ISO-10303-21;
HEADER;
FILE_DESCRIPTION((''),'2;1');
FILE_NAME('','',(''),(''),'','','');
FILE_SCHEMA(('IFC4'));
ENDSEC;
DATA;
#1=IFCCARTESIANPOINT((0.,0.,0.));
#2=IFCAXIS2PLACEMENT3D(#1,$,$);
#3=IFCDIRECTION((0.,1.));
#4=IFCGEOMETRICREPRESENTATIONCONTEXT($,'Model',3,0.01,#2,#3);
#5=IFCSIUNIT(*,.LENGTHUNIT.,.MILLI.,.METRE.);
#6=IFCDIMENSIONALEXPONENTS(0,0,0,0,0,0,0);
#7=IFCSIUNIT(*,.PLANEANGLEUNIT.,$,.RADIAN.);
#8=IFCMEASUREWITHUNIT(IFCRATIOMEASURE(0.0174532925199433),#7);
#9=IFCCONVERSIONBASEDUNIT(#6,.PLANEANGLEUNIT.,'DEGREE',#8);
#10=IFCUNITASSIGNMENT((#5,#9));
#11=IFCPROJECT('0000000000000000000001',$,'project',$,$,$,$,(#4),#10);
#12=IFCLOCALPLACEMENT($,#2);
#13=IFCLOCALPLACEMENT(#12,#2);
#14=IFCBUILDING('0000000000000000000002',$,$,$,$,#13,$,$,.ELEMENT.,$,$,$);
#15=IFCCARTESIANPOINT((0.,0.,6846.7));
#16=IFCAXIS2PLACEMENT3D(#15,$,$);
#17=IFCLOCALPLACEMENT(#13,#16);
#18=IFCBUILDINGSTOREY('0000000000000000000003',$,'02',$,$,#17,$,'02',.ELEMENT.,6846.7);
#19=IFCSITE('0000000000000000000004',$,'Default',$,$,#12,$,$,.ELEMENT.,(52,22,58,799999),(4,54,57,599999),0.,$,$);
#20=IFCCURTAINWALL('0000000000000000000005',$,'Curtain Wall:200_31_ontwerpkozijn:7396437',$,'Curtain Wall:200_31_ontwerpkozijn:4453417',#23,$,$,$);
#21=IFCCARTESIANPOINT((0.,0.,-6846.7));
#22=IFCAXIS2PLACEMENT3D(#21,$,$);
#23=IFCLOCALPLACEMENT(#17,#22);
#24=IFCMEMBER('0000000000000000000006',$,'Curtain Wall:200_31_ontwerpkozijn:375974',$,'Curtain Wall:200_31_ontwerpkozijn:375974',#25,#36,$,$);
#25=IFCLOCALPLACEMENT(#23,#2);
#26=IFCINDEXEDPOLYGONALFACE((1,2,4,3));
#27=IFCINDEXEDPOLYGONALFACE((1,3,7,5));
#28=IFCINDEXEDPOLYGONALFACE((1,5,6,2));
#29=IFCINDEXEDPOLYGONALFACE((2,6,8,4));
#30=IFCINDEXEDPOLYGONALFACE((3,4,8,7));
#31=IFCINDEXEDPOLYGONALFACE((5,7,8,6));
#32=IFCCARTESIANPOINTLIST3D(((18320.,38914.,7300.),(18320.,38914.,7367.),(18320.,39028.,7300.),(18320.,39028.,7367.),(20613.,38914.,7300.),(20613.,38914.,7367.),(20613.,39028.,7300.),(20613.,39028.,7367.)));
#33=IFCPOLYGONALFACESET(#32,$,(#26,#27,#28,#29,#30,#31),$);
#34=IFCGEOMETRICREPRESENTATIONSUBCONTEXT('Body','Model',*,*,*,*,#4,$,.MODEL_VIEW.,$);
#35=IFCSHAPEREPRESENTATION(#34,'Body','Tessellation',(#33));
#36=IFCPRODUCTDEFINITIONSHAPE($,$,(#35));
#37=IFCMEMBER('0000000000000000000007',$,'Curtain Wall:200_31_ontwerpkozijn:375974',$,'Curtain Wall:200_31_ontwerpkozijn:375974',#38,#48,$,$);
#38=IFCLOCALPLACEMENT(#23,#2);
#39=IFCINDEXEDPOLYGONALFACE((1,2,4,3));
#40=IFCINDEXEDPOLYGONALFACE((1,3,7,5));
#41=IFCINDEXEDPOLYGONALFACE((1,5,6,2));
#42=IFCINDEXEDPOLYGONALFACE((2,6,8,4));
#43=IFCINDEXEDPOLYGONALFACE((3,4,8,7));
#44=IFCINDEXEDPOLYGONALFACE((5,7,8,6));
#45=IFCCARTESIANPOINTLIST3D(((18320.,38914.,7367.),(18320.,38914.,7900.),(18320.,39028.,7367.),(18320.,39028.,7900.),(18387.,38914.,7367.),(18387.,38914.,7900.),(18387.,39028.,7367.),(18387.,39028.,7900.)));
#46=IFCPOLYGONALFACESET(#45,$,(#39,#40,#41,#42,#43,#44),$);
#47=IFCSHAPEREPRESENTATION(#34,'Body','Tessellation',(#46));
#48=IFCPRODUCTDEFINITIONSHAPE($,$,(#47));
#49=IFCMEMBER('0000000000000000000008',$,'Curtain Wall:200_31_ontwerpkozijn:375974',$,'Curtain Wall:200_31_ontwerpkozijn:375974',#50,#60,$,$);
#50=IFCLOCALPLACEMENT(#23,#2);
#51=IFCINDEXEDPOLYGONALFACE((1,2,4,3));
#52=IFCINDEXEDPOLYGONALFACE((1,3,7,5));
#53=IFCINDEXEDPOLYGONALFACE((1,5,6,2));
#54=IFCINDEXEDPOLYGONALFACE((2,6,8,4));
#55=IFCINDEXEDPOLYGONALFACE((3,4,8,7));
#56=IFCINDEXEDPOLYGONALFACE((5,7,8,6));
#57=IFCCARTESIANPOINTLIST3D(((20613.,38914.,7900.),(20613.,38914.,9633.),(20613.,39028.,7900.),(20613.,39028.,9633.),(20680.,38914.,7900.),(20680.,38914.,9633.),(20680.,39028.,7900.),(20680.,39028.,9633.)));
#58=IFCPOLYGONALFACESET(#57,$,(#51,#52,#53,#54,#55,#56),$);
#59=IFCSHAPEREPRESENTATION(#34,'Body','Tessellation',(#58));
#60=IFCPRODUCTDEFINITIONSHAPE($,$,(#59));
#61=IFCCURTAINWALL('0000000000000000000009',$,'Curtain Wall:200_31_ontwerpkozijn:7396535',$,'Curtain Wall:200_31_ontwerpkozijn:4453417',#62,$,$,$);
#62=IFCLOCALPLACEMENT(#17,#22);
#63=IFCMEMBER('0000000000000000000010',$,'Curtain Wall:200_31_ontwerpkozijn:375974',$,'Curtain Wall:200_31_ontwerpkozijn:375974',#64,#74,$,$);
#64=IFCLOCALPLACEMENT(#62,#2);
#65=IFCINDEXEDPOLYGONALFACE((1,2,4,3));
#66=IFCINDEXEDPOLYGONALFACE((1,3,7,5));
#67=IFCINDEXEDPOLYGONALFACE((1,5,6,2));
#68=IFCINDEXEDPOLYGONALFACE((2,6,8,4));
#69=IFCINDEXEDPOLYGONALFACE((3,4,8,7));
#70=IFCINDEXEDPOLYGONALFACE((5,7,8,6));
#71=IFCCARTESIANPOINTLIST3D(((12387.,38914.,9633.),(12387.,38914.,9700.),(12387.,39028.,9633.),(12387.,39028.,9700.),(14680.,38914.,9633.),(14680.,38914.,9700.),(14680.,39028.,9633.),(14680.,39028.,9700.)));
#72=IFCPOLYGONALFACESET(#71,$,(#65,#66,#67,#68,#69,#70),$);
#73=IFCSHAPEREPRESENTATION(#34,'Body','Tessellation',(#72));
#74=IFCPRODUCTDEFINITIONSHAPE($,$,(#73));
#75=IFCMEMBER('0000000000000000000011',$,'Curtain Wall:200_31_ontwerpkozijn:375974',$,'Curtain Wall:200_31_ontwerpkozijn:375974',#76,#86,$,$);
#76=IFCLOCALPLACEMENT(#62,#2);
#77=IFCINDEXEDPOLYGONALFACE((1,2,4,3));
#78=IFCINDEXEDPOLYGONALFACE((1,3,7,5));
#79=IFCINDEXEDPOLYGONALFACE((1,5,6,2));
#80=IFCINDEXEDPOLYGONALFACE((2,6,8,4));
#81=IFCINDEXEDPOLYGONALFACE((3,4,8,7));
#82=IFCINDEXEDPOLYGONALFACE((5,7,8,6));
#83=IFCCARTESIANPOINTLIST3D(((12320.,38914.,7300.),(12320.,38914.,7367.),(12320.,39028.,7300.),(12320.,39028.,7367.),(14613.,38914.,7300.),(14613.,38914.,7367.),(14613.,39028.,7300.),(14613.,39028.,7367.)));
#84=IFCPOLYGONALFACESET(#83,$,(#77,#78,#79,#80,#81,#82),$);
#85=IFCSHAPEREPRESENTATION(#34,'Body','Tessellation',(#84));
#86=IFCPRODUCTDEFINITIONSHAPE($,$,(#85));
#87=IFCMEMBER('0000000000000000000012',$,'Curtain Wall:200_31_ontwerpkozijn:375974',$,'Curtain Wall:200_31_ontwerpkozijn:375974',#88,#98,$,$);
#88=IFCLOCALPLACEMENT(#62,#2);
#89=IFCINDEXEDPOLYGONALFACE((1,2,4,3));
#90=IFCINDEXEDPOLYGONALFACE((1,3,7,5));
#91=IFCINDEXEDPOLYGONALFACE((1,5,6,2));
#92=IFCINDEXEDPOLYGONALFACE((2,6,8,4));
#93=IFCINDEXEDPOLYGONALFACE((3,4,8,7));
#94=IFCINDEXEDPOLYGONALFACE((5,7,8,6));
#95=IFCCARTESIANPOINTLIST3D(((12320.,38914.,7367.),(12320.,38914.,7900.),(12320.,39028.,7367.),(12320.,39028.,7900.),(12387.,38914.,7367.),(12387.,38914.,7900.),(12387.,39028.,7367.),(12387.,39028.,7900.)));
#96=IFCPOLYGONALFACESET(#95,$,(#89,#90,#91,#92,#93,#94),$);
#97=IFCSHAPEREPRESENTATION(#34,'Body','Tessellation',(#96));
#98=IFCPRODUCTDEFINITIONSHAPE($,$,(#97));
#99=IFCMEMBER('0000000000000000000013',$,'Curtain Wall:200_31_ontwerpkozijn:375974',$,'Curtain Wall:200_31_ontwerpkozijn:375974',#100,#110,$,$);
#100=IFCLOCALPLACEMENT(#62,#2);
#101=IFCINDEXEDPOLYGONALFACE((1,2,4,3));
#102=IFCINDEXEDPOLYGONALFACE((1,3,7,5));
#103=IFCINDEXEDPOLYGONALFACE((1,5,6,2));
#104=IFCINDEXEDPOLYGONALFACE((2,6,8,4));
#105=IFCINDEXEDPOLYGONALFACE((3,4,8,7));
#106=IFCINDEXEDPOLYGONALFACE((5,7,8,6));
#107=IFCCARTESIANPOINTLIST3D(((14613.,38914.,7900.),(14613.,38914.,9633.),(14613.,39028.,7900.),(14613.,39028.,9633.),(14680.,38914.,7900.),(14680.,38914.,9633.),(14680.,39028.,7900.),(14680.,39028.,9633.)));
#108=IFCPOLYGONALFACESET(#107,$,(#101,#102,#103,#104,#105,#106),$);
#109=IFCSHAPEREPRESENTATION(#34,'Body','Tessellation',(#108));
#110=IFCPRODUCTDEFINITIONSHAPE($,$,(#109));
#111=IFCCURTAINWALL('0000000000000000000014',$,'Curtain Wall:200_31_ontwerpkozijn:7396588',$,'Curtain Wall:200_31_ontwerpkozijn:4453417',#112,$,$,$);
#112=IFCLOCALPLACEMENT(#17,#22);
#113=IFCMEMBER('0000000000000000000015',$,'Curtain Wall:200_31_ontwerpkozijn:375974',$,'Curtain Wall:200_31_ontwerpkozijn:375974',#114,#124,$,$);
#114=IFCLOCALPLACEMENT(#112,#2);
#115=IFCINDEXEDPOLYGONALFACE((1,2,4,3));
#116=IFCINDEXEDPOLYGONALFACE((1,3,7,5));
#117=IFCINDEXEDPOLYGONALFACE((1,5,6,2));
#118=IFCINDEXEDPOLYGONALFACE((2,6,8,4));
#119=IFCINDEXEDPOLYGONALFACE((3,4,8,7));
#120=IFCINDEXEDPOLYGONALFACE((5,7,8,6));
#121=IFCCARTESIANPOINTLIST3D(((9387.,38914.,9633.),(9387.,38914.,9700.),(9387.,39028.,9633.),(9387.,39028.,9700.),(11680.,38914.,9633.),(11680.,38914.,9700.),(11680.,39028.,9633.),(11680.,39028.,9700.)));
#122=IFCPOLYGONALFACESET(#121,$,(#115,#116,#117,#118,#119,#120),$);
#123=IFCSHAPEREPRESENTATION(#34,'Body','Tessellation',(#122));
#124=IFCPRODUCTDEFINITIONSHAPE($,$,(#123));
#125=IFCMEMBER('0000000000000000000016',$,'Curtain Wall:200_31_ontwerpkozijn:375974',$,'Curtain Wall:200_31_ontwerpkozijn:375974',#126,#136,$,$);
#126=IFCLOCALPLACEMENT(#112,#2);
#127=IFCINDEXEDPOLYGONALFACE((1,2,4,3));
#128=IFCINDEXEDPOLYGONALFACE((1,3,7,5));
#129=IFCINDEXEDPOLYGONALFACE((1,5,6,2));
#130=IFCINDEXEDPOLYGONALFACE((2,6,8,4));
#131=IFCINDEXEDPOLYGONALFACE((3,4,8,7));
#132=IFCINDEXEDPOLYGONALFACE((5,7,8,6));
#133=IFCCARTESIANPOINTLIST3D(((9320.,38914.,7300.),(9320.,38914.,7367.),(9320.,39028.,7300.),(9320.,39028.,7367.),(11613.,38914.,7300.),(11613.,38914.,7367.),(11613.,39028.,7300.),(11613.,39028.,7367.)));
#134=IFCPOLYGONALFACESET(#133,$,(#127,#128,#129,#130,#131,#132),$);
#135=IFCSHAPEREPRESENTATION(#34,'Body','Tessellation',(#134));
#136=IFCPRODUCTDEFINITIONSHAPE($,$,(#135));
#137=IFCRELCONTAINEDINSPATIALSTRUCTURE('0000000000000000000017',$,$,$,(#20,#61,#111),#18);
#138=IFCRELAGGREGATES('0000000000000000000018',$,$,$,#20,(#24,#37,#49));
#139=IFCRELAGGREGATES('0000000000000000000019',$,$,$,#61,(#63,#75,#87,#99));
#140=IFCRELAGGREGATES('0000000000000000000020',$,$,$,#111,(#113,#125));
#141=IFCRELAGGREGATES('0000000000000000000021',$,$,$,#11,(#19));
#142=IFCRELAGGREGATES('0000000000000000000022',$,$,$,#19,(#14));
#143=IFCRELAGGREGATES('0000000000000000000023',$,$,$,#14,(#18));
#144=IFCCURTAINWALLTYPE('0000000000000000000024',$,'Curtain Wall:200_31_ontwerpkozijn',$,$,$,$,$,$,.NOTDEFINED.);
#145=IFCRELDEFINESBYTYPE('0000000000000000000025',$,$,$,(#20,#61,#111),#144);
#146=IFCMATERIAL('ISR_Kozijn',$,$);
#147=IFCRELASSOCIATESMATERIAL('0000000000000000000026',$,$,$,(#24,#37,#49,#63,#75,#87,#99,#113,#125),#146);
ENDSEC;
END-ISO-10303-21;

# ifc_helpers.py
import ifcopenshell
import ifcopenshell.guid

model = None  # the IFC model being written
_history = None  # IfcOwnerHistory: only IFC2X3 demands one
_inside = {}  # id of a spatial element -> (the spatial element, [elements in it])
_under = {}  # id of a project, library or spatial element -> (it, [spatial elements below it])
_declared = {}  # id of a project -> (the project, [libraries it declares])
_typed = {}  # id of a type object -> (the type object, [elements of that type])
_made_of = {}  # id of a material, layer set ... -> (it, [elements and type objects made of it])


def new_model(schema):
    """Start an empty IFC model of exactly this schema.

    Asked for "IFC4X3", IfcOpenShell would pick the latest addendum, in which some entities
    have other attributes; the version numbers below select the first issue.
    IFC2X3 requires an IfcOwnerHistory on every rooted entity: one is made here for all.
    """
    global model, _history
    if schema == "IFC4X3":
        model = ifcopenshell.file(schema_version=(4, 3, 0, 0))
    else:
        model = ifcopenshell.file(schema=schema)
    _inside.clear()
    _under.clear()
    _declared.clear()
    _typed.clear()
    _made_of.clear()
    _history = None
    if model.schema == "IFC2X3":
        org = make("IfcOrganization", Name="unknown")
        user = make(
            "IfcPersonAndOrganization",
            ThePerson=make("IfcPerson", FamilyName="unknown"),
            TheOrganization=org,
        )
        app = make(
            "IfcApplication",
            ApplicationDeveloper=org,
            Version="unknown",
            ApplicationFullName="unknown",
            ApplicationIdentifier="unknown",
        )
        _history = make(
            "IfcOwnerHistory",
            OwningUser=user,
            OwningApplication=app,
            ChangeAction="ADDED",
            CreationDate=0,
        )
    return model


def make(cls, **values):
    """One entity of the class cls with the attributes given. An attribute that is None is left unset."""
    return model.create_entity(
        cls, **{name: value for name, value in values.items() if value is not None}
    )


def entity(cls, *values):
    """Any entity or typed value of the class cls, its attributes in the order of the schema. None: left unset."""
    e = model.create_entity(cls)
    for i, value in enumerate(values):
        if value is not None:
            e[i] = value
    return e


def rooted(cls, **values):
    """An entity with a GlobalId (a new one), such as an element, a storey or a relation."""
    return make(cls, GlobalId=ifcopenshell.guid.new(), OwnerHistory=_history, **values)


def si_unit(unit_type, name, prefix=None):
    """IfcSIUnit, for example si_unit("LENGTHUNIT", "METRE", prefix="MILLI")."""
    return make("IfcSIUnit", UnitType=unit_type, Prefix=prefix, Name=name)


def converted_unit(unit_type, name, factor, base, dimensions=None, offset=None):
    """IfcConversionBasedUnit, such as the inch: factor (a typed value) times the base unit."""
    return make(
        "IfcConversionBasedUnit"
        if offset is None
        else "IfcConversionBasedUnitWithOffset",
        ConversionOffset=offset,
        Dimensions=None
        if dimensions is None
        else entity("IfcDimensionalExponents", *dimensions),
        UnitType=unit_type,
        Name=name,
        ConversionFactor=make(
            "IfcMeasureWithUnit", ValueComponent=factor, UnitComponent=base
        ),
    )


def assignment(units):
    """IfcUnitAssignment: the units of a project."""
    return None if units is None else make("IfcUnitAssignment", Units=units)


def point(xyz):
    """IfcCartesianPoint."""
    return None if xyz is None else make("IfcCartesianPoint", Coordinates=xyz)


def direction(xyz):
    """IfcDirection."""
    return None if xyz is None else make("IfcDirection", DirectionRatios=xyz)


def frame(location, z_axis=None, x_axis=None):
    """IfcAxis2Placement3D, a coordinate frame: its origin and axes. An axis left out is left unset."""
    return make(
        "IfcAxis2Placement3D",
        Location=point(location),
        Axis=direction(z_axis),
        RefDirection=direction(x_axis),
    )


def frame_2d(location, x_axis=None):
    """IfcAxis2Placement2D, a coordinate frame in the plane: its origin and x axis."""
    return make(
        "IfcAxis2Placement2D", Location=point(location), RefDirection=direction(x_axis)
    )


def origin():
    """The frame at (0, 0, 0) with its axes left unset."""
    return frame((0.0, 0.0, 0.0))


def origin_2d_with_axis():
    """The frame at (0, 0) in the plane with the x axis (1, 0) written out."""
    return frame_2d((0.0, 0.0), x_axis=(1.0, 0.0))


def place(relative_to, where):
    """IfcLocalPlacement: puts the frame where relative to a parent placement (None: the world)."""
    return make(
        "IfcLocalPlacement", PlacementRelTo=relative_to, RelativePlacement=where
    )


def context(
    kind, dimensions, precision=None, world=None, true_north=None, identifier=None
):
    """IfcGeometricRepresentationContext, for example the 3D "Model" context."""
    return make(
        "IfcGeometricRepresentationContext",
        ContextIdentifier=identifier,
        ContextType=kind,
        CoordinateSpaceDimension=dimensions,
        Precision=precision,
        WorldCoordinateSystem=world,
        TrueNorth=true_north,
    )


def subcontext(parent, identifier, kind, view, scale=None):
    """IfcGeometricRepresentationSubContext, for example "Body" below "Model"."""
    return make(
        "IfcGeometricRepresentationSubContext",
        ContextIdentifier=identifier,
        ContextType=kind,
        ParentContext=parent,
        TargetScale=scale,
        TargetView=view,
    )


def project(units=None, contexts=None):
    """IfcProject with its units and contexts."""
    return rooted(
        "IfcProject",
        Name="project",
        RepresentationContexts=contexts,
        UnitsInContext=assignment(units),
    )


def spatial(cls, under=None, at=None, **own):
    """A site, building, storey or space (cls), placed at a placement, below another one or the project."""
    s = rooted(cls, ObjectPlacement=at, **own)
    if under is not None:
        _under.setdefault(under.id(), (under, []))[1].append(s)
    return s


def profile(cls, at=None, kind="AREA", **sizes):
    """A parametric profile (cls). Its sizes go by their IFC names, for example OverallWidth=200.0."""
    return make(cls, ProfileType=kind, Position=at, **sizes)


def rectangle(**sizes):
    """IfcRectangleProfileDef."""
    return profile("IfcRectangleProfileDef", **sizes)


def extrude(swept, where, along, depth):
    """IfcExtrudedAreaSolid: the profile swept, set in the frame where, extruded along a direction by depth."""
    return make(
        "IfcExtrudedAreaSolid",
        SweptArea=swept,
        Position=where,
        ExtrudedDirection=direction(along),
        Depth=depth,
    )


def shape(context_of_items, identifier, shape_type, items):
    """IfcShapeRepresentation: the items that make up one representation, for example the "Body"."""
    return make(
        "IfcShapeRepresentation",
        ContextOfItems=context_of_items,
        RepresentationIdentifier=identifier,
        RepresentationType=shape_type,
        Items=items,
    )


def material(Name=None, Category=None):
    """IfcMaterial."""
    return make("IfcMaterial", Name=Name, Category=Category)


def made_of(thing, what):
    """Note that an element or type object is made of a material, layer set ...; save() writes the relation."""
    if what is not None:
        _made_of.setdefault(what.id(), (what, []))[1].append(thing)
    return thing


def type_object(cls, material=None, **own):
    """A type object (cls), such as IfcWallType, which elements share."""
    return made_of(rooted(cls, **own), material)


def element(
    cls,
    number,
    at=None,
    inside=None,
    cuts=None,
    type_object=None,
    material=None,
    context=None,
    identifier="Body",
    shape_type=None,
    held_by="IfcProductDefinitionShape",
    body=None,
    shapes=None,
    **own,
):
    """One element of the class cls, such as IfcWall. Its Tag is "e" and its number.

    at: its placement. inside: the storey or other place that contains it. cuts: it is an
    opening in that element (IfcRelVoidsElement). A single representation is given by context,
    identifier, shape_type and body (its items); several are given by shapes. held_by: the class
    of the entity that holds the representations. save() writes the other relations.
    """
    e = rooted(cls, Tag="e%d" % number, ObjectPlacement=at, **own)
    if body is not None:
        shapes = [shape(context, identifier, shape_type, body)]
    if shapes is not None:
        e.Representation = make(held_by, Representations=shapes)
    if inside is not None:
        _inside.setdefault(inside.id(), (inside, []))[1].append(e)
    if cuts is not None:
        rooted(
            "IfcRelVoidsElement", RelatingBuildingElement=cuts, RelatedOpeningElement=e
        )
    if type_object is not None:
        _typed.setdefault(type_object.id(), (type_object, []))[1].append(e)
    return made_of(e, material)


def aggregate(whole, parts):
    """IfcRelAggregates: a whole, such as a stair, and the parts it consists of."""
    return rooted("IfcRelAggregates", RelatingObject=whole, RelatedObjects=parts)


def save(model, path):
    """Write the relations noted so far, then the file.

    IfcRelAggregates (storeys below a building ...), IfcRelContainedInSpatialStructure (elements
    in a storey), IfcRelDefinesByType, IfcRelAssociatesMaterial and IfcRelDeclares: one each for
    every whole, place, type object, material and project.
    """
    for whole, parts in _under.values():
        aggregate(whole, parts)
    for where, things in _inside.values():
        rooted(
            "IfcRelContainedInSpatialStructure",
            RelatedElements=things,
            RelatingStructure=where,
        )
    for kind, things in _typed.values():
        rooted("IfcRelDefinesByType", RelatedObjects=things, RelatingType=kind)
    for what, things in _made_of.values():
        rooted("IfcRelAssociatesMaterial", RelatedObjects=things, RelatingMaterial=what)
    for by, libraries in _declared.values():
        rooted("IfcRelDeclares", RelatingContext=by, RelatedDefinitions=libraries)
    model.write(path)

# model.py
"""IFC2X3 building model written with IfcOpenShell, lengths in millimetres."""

from ifc_helpers import new_model, entity, si_unit, converted_unit, direction, frame, frame_2d, origin, origin_2d_with_axis, place, context, subcontext, project, spatial, rectangle, extrude, material, type_object, element, aggregate, save


model = new_model("IFC2X3")

# Units and contexts
model_context = context("Model", 3, precision=0.01, world=origin(), true_north=direction((0.0, 1.0)))
body_context = subcontext(model_context, "Body", "Model", "MODEL_VIEW")
ifc_project = project(units=[si_unit("LENGTHUNIT", "METRE", prefix="MILLI"), converted_unit("PLANEANGLEUNIT", "DEGREE", entity("IfcRatioMeasure", 0.0174532925199433), si_unit("PLANEANGLEUNIT", "RADIAN"), dimensions=[0, 0, 0, 0, 0, 0, 0])], contexts=[model_context])

# Site, building, storey
site_placement = place(None, origin())
site = spatial("IfcSite", under=ifc_project, at=site_placement, Name="Default", CompositionType="ELEMENT", RefLatitude=(52, 22, 58, 799999), RefLongitude=(4, 54, 57, 599999), RefElevation=0.0)
building_placement = place(site_placement, origin())
building = spatial("IfcBuilding", under=site, at=building_placement, CompositionType="ELEMENT")
storey_placement = place(building_placement, frame((0.0, 0.0, 6846.7)))
storey = spatial("IfcBuildingStorey", under=building, at=storey_placement, Name="02", LongName="02", CompositionType="ELEMENT", Elevation=6846.7)

# Curtain walls, members
curtain_wall_type = type_object("IfcCurtainWallType", Name="Curtain Wall:200_31_ontwerpkozijn", PredefinedType="NOTDEFINED")
ifc_material = material(Name="ISR_Kozijn")
curtain_wall_1_placement = place(storey_placement, frame((0.0, 0.0, -6846.7)))
curtain_wall_1 = element("IfcCurtainWall", 1, at=curtain_wall_1_placement, inside=storey, type_object=curtain_wall_type, Name="Curtain Wall:200_31_ontwerpkozijn:7396437", ObjectType="Curtain Wall:200_31_ontwerpkozijn:4453417")
member_1_placement = place(curtain_wall_1_placement, origin())
member_1 = element("IfcMember", 2, at=member_1_placement, material=ifc_material, Name="Curtain Wall:200_31_ontwerpkozijn:375974", ObjectType="Curtain Wall:200_31_ontwerpkozijn:375974", context=body_context, shape_type="SweptSolid", body=[
    extrude(rectangle(XDim=67.0, YDim=114.0, at=frame_2d((0.0, 0.0), x_axis=(1.0, 0.0))), frame((20613.0, 38971.0, 7333.5), z_axis=(-1.0, 0.0, 0.0), x_axis=(0.0, 0.0, -1.0)), (0.0, 0.0, 1.0), 2293.0),
])
member_2_placement = place(curtain_wall_1_placement, origin())
member_2 = element("IfcMember", 3, at=member_2_placement, material=ifc_material, Name="Curtain Wall:200_31_ontwerpkozijn:375974", ObjectType="Curtain Wall:200_31_ontwerpkozijn:375974", context=body_context, shape_type="SweptSolid", body=[
    extrude(rectangle(XDim=67.0, YDim=114.0, at=frame_2d((0.0, 0.0), x_axis=(1.0, 0.0))), frame((18353.5, 38971.0, 7367.0), z_axis=(0.0, 0.0, 1.0), x_axis=(-1.0, 0.0, 0.0)), (0.0, 0.0, 1.0), 533.0),
])
member_3_placement = place(curtain_wall_1_placement, origin())
member_3 = element("IfcMember", 4, at=member_3_placement, material=ifc_material, Name="Curtain Wall:200_31_ontwerpkozijn:375974", ObjectType="Curtain Wall:200_31_ontwerpkozijn:375974", context=body_context, shape_type="SweptSolid", body=[
    extrude(rectangle(XDim=67.0, YDim=114.0, at=origin_2d_with_axis()), frame((20646.5, 38971.0, 9633.0), z_axis=(0.0, 0.0, -1.0), x_axis=(-1.0, 0.0, 0.0)), (0.0, 0.0, 1.0), 1733.0),
])
aggregate(curtain_wall_1, [member_1, member_2, member_3])
curtain_wall_2_placement = place(storey_placement, frame((0.0, 0.0, -6846.7)))
curtain_wall_2 = element("IfcCurtainWall", 5, at=curtain_wall_2_placement, inside=storey, type_object=curtain_wall_type, Name="Curtain Wall:200_31_ontwerpkozijn:7396535", ObjectType="Curtain Wall:200_31_ontwerpkozijn:4453417")
member_4_placement = place(curtain_wall_2_placement, origin())
member_4 = element("IfcMember", 6, at=member_4_placement, material=ifc_material, Name="Curtain Wall:200_31_ontwerpkozijn:375974", ObjectType="Curtain Wall:200_31_ontwerpkozijn:375974", context=body_context, shape_type="SweptSolid", body=[
    extrude(rectangle(XDim=67.0, YDim=114.0, at=frame_2d((0.0, 0.0), x_axis=(1.0, 0.0))), frame((12387.0, 38971.0, 9666.5), z_axis=(1.0, 0.0, 0.0), x_axis=(0.0, 0.0, -1.0)), (0.0, 0.0, 1.0), 2293.0),
])
member_5_placement = place(curtain_wall_2_placement, origin())
member_5 = element("IfcMember", 7, at=member_5_placement, material=ifc_material, Name="Curtain Wall:200_31_ontwerpkozijn:375974", ObjectType="Curtain Wall:200_31_ontwerpkozijn:375974", context=body_context, shape_type="SweptSolid", body=[
    extrude(rectangle(XDim=67.0, YDim=114.0, at=frame_2d((0.0, 0.0), x_axis=(1.0, 0.0))), frame((14613.0, 38971.0, 7333.5), z_axis=(-1.0, 0.0, 0.0), x_axis=(0.0, 0.0, -1.0)), (0.0, 0.0, 1.0), 2293.0),
])
member_6_placement = place(curtain_wall_2_placement, origin())
member_6 = element("IfcMember", 8, at=member_6_placement, material=ifc_material, Name="Curtain Wall:200_31_ontwerpkozijn:375974", ObjectType="Curtain Wall:200_31_ontwerpkozijn:375974", context=body_context, shape_type="SweptSolid", body=[
    extrude(rectangle(XDim=67.0, YDim=114.0, at=frame_2d((0.0, 0.0), x_axis=(1.0, 0.0))), frame((12353.5, 38971.0, 7367.0), z_axis=(0.0, 0.0, 1.0), x_axis=(-1.0, 0.0, 0.0)), (0.0, 0.0, 1.0), 533.0),
])
member_7_placement = place(curtain_wall_2_placement, origin())
member_7 = element("IfcMember", 9, at=member_7_placement, material=ifc_material, Name="Curtain Wall:200_31_ontwerpkozijn:375974", ObjectType="Curtain Wall:200_31_ontwerpkozijn:375974", context=body_context, shape_type="SweptSolid", body=[
    extrude(rectangle(XDim=67.0, YDim=114.0, at=frame_2d((0.0, 0.0), x_axis=(1.0, 0.0))), frame((14646.5, 38971.0, 9633.0), z_axis=(0.0, 0.0, -1.0), x_axis=(-1.0, 0.0, 0.0)), (0.0, 0.0, 1.0), 1733.0),
])
aggregate(curtain_wall_2, [member_4, member_5, member_6, member_7])
curtain_wall_3_placement = place(storey_placement, frame((0.0, 0.0, -6846.7)))
curtain_wall_3 = element("IfcCurtainWall", 10, at=curtain_wall_3_placement, inside=storey, type_object=curtain_wall_type, Name="Curtain Wall:200_31_ontwerpkozijn:7396588", ObjectType="Curtain Wall:200_31_ontwerpkozijn:4453417")
member_8_placement = place(curtain_wall_3_placement, origin())
member_8 = element("IfcMember", 11, at=member_8_placement, material=ifc_material, Name="Curtain Wall:200_31_ontwerpkozijn:375974", ObjectType="Curtain Wall:200_31_ontwerpkozijn:375974", context=body_context, shape_type="SweptSolid", body=[
    extrude(rectangle(XDim=67.0, YDim=114.0, at=frame_2d((0.0, 0.0), x_axis=(1.0, 0.0))), frame((9387.0, 38971.0, 9666.5), z_axis=(1.0, 0.0, 0.0), x_axis=(0.0, 0.0, -1.0)), (0.0, 0.0, 1.0), 2293.0),
])
member_9_placement = place(curtain_wall_3_placement, origin())
member_9 = element("IfcMember", 12, at=member_9_placement, material=ifc_material, Name="Curtain Wall:200_31_ontwerpkozijn:375974", ObjectType="Curtain Wall:200_31_ontwerpkozijn:375974", context=body_context, shape_type="SweptSolid", body=[
    extrude(rectangle(XDim=67.0, YDim=114.0, at=frame_2d((0.0, 0.0), x_axis=(1.0, 0.0))), frame((11613.0, 38971.0, 7333.5), z_axis=(-1.0, 0.0, 0.0), x_axis=(0.0, 0.0, -1.0)), (0.0, 0.0, 1.0), 2293.0),
])
aggregate(curtain_wall_3, [member_8, member_9])

save(model, "model.ifc")
